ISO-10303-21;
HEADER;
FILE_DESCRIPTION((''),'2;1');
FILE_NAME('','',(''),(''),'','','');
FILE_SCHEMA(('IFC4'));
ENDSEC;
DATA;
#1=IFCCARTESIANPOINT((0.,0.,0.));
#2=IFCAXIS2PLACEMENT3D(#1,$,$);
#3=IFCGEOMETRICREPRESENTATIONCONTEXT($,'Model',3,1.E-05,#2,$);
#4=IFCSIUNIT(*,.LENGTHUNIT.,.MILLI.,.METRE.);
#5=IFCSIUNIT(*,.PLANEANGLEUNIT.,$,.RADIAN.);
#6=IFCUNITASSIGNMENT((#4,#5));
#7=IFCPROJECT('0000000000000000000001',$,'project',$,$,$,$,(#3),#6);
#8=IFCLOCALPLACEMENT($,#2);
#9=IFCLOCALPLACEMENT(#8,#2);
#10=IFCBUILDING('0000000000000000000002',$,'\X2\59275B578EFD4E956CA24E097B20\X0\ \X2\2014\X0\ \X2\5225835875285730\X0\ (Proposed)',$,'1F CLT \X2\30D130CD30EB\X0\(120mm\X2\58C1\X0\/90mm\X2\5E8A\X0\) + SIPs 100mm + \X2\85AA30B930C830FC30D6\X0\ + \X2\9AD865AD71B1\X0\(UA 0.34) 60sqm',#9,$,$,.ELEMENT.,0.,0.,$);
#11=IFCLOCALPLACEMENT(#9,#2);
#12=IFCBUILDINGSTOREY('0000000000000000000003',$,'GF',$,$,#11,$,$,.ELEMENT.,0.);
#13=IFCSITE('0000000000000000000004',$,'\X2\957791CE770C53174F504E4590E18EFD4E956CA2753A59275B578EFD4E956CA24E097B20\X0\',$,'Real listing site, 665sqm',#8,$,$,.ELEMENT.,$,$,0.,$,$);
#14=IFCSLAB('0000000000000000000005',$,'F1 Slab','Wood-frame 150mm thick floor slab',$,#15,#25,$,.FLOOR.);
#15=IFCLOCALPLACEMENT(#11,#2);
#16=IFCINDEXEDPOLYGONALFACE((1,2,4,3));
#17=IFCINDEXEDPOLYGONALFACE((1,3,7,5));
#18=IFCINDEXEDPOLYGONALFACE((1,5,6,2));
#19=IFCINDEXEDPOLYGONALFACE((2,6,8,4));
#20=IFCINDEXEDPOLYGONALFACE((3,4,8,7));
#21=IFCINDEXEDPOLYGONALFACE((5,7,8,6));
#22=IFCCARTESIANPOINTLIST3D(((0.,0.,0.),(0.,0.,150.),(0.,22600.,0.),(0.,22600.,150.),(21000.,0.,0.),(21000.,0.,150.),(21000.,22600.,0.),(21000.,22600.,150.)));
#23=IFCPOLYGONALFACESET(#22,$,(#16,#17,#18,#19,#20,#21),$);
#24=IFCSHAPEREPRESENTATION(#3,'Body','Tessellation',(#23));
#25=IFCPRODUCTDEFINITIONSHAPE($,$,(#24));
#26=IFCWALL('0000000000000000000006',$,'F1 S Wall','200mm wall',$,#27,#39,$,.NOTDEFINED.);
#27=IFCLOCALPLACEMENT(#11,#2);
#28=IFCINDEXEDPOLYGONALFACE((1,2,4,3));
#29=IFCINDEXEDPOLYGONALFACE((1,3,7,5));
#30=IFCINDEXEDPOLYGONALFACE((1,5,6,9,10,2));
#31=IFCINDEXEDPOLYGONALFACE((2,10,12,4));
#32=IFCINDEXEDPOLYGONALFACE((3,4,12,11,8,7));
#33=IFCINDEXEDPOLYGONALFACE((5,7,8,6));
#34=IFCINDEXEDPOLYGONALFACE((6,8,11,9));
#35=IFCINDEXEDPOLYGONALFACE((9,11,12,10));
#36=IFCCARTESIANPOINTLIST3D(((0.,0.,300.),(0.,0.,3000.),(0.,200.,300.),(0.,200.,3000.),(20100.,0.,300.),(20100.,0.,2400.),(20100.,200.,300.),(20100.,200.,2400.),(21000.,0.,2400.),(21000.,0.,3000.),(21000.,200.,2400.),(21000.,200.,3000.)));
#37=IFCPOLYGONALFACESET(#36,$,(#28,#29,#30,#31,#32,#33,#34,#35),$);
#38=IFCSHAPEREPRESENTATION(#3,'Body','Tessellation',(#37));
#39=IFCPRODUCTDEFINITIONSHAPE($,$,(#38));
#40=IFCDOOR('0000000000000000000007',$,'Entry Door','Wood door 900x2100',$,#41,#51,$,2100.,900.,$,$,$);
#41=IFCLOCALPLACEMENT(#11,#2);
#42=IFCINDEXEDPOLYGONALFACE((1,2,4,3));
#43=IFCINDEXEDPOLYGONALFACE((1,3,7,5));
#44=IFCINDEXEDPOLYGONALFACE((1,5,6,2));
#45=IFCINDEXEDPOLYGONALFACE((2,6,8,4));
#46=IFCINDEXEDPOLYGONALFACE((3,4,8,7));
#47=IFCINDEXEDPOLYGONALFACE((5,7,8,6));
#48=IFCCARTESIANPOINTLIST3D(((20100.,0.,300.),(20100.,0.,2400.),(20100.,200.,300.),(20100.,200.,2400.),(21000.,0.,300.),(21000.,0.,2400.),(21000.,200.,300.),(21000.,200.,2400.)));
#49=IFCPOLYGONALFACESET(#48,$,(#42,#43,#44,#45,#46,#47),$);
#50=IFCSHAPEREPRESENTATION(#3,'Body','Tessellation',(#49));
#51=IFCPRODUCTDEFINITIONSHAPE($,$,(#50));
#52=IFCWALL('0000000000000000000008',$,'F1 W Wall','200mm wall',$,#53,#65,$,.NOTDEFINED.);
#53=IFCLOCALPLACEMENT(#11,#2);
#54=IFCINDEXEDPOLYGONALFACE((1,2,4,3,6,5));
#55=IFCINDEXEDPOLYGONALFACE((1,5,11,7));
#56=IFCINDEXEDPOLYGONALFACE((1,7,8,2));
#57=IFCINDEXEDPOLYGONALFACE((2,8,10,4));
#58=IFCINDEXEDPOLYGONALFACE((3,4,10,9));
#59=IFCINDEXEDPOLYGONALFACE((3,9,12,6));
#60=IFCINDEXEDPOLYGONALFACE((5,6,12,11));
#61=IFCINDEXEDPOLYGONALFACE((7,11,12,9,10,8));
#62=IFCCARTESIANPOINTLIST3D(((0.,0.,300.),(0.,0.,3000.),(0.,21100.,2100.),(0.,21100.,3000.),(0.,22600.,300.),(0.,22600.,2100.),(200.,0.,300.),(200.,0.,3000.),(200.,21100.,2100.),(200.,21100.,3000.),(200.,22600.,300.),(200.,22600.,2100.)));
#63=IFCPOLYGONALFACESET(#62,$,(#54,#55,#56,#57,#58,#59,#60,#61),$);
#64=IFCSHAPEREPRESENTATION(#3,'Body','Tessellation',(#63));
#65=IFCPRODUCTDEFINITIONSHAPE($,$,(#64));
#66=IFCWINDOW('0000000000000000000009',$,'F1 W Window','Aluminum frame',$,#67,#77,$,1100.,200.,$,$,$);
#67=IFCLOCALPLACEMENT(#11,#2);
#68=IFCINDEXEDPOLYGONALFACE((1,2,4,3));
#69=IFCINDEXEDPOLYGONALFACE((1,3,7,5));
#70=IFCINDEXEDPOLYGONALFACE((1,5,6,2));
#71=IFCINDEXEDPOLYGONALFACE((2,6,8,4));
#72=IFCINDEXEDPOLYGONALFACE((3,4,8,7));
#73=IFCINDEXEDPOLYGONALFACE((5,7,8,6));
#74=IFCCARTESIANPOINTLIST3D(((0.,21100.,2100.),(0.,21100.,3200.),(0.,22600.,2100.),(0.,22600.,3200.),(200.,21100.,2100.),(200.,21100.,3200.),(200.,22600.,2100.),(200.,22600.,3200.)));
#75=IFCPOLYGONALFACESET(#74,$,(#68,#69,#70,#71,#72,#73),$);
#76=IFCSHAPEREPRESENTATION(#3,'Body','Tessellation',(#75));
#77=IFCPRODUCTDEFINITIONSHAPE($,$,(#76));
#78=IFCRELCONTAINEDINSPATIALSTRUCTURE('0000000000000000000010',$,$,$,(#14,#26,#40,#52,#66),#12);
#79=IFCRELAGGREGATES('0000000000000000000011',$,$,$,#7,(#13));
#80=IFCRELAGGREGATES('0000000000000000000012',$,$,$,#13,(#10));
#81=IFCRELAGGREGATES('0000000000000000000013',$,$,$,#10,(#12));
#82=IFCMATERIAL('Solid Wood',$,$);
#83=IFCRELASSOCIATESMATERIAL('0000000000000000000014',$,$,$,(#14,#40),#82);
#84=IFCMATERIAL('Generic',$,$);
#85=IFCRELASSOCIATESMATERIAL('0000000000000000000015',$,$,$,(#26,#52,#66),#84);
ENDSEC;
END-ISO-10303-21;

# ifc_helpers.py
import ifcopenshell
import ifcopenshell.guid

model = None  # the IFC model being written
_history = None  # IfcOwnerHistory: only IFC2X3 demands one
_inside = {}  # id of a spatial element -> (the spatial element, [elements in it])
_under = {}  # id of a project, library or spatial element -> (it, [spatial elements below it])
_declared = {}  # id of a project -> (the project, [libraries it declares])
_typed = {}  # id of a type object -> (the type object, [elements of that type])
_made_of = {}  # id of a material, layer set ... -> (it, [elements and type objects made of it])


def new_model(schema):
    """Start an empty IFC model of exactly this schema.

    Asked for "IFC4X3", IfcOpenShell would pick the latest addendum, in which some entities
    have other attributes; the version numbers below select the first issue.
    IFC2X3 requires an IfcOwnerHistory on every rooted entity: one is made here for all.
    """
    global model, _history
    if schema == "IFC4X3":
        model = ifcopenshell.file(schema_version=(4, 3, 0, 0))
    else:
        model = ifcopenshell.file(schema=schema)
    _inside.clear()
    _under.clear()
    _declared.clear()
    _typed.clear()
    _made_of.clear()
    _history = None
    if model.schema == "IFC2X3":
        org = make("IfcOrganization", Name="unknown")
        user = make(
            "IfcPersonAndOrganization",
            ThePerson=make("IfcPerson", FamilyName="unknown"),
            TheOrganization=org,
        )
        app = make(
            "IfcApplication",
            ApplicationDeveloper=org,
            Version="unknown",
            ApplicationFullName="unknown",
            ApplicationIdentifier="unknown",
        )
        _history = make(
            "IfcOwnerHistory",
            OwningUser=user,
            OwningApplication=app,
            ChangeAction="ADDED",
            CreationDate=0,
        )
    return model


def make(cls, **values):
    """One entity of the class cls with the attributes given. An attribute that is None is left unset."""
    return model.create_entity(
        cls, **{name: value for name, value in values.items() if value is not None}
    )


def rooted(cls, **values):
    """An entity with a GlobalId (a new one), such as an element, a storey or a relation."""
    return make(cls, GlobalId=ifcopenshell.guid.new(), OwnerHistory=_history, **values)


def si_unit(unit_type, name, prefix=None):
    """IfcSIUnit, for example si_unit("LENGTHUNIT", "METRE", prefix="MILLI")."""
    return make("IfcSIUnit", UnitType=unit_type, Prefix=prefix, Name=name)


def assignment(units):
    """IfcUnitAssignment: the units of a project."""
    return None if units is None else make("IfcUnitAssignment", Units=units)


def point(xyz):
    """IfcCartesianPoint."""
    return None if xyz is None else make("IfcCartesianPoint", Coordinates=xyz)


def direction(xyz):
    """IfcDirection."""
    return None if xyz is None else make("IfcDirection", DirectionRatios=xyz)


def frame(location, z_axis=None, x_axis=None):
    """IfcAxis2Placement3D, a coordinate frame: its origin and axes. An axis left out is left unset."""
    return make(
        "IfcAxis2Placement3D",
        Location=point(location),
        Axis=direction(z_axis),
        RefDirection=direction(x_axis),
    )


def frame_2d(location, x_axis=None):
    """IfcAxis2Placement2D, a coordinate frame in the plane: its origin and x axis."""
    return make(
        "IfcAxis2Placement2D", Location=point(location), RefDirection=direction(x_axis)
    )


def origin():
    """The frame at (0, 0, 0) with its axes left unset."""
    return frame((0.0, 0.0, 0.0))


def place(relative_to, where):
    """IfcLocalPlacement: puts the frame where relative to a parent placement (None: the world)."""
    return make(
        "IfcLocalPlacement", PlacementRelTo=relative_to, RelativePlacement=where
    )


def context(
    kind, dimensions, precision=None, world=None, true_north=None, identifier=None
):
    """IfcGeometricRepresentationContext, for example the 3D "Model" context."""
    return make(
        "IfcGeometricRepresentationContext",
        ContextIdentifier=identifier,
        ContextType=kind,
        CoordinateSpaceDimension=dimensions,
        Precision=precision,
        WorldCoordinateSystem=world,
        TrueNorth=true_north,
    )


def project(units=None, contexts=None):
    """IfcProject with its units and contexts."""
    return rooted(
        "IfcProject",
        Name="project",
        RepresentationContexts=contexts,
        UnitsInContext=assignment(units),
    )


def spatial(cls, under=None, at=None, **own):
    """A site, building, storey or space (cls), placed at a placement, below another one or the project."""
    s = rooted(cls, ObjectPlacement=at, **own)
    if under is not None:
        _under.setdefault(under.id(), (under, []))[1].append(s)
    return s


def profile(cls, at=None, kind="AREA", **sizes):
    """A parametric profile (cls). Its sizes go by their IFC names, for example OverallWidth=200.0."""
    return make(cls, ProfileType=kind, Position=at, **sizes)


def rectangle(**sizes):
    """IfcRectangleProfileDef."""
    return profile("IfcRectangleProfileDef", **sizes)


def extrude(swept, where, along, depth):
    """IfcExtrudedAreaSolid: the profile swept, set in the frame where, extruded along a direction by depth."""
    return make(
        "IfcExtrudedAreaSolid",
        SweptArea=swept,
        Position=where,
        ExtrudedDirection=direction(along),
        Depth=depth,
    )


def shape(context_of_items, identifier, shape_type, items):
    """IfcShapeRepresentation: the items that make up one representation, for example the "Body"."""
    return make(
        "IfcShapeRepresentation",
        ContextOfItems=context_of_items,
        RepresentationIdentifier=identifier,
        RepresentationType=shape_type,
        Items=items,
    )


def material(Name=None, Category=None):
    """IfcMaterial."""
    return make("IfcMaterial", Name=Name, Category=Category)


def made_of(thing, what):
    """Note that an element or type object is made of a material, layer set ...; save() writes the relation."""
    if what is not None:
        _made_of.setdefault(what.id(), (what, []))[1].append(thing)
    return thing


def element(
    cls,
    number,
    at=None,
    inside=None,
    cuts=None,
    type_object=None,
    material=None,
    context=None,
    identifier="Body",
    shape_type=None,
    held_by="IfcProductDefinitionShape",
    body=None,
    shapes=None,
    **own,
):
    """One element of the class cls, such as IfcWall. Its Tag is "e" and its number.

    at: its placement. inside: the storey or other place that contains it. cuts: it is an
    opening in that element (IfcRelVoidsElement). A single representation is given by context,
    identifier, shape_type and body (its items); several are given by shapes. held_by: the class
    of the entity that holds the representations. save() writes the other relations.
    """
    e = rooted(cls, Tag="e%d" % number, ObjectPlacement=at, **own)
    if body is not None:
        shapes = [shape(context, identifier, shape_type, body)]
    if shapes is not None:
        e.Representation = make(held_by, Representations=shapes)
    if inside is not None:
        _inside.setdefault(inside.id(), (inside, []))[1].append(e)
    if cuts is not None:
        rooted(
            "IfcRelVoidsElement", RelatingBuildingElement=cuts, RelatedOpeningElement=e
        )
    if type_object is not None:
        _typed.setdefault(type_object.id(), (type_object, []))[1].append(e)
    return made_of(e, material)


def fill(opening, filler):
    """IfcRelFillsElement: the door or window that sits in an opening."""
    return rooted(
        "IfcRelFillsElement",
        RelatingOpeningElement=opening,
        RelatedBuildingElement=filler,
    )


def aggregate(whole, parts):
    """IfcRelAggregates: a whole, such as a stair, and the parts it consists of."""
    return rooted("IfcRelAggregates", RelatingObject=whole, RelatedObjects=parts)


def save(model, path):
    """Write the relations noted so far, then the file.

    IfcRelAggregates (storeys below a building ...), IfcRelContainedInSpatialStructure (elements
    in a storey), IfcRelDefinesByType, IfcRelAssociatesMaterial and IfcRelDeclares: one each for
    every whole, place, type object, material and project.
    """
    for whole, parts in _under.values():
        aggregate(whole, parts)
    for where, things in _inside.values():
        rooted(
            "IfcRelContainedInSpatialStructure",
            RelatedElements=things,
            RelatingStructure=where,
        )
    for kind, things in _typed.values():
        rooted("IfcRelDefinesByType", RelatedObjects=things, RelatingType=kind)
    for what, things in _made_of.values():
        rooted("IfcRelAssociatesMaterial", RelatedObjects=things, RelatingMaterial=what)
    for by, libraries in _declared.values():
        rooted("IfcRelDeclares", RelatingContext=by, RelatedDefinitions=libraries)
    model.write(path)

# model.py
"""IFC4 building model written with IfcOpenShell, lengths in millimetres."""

from ifc_helpers import new_model, si_unit, frame, frame_2d, origin, place, context, project, spatial, rectangle, extrude, material, element, fill, save


model = new_model("IFC4")

# Units and contexts
model_context = context("Model", 3, precision=1e-05, world=origin())
ifc_project = project(units=[si_unit("LENGTHUNIT", "METRE", prefix="MILLI"), si_unit("PLANEANGLEUNIT", "RADIAN")], contexts=[model_context])

# Site, building, storey
site_placement = place(None, origin())
site = spatial("IfcSite", under=ifc_project, at=site_placement, Name="長野県北佐久郡軽井沢町大字軽井沢三笠", ObjectType="Real listing site, 665sqm", CompositionType="ELEMENT", RefElevation=0.0)
building_placement = place(site_placement, origin())
building = spatial("IfcBuilding", under=site, at=building_placement, Name="大字軽井沢三笠 — 別荘用地 (Proposed)", ObjectType="1F CLT パネル(120mm壁/90mm床) + SIPs 100mm + 薪ストーブ + 高断熱(UA 0.34) 60sqm", CompositionType="ELEMENT", ElevationOfRefHeight=0.0, ElevationOfTerrain=0.0)
storey_placement = place(building_placement, origin())
storey = spatial("IfcBuildingStorey", under=building, at=storey_placement, Name="GF", CompositionType="ELEMENT", Elevation=0.0)

# Slab
ifc_material_1 = material(Name="Solid Wood")
slab_placement = place(storey_placement, origin())
element("IfcSlab", 1, at=slab_placement, inside=storey, material=ifc_material_1, Name="F1 Slab", Description="Wood-frame 150mm thick floor slab", PredefinedType="FLOOR", context=model_context, shape_type="SweptSolid", body=[
    extrude(rectangle(XDim=21000.0, YDim=22600.0, at=frame_2d((10500.0, 11300.0))), origin(), (0.0, 0.0, 1.0), 150.0),
])

# Shared definitions
ifc_material_2 = material(Name="Generic")

# Wall, opening, door
wall_1_placement = place(storey_placement, frame((0.0, 0.0, 150.0)))
wall_1 = element("IfcWall", 2, at=wall_1_placement, inside=storey, material=ifc_material_2, Name="F1 S Wall", Description="200mm wall", PredefinedType="NOTDEFINED", context=model_context, shape_type="SweptSolid", body=[
    extrude(rectangle(XDim=21000.0, YDim=200.0, at=frame_2d((10500.0, 100.0))), frame((0.0, 0.0, 150.0)), (0.0, 0.0, 1.0), 2700.0),
])
opening_1_placement = place(storey_placement, frame((10050.0, 0.0, 150.0)))
opening_1 = element("IfcOpeningElement", 3, at=opening_1_placement, cuts=wall_1, PredefinedType="NOTDEFINED", context=model_context, shape_type="SweptSolid", body=[
    extrude(rectangle(XDim=900.0, YDim=200.0, at=frame_2d((450.0, 100.0))), frame((10050.0, 0.0, 150.0)), (0.0, 0.0, 1.0), 2100.0),
])
door_placement = place(storey_placement, frame((10050.0, 0.0, 150.0)))
door = element("IfcDoor", 4, at=door_placement, inside=storey, material=ifc_material_1, Name="Entry Door", Description="Wood door 900x2100", OverallHeight=2100.0, OverallWidth=900.0, context=model_context, shape_type="SweptSolid", body=[
    extrude(rectangle(XDim=900.0, YDim=200.0, at=frame_2d((450.0, 100.0))), frame((10050.0, 0.0, 150.0)), (0.0, 0.0, 1.0), 2100.0),
])
fill(opening_1, door)

# Wall, opening, window
wall_2_placement = place(storey_placement, frame((0.0, 0.0, 150.0)))
wall_2 = element("IfcWall", 5, at=wall_2_placement, inside=storey, material=ifc_material_2, Name="F1 W Wall", Description="200mm wall", PredefinedType="NOTDEFINED", context=model_context, shape_type="SweptSolid", body=[
    extrude(rectangle(XDim=200.0, YDim=22600.0, at=frame_2d((100.0, 11300.0))), frame((0.0, 0.0, 150.0)), (0.0, 0.0, 1.0), 2700.0),
])
opening_2_placement = place(storey_placement, frame((0.0, 10550.0, 1050.0)))
opening_2 = element("IfcOpeningElement", 6, at=opening_2_placement, cuts=wall_2, PredefinedType="NOTDEFINED", context=model_context, shape_type="SweptSolid", body=[
    extrude(rectangle(XDim=200.0, YDim=1500.0, at=frame_2d((100.0, 750.0))), frame((0.0, 10550.0, 1050.0)), (0.0, 0.0, 1.0), 1100.0),
])
window_1_placement = place(storey_placement, frame((0.0, 10550.0, 1050.0)))
window_1 = element("IfcWindow", 7, at=window_1_placement, inside=storey, material=ifc_material_2, Name="F1 W Window", Description="Aluminum frame", OverallHeight=1100.0, OverallWidth=200.0, context=model_context, shape_type="SweptSolid", body=[
    extrude(rectangle(XDim=200.0, YDim=1500.0, at=frame_2d((100.0, 750.0))), frame((0.0, 10550.0, 1050.0)), (0.0, 0.0, 1.0), 1100.0),
])
fill(opening_2, window_1)

save(model, "model.ifc")
